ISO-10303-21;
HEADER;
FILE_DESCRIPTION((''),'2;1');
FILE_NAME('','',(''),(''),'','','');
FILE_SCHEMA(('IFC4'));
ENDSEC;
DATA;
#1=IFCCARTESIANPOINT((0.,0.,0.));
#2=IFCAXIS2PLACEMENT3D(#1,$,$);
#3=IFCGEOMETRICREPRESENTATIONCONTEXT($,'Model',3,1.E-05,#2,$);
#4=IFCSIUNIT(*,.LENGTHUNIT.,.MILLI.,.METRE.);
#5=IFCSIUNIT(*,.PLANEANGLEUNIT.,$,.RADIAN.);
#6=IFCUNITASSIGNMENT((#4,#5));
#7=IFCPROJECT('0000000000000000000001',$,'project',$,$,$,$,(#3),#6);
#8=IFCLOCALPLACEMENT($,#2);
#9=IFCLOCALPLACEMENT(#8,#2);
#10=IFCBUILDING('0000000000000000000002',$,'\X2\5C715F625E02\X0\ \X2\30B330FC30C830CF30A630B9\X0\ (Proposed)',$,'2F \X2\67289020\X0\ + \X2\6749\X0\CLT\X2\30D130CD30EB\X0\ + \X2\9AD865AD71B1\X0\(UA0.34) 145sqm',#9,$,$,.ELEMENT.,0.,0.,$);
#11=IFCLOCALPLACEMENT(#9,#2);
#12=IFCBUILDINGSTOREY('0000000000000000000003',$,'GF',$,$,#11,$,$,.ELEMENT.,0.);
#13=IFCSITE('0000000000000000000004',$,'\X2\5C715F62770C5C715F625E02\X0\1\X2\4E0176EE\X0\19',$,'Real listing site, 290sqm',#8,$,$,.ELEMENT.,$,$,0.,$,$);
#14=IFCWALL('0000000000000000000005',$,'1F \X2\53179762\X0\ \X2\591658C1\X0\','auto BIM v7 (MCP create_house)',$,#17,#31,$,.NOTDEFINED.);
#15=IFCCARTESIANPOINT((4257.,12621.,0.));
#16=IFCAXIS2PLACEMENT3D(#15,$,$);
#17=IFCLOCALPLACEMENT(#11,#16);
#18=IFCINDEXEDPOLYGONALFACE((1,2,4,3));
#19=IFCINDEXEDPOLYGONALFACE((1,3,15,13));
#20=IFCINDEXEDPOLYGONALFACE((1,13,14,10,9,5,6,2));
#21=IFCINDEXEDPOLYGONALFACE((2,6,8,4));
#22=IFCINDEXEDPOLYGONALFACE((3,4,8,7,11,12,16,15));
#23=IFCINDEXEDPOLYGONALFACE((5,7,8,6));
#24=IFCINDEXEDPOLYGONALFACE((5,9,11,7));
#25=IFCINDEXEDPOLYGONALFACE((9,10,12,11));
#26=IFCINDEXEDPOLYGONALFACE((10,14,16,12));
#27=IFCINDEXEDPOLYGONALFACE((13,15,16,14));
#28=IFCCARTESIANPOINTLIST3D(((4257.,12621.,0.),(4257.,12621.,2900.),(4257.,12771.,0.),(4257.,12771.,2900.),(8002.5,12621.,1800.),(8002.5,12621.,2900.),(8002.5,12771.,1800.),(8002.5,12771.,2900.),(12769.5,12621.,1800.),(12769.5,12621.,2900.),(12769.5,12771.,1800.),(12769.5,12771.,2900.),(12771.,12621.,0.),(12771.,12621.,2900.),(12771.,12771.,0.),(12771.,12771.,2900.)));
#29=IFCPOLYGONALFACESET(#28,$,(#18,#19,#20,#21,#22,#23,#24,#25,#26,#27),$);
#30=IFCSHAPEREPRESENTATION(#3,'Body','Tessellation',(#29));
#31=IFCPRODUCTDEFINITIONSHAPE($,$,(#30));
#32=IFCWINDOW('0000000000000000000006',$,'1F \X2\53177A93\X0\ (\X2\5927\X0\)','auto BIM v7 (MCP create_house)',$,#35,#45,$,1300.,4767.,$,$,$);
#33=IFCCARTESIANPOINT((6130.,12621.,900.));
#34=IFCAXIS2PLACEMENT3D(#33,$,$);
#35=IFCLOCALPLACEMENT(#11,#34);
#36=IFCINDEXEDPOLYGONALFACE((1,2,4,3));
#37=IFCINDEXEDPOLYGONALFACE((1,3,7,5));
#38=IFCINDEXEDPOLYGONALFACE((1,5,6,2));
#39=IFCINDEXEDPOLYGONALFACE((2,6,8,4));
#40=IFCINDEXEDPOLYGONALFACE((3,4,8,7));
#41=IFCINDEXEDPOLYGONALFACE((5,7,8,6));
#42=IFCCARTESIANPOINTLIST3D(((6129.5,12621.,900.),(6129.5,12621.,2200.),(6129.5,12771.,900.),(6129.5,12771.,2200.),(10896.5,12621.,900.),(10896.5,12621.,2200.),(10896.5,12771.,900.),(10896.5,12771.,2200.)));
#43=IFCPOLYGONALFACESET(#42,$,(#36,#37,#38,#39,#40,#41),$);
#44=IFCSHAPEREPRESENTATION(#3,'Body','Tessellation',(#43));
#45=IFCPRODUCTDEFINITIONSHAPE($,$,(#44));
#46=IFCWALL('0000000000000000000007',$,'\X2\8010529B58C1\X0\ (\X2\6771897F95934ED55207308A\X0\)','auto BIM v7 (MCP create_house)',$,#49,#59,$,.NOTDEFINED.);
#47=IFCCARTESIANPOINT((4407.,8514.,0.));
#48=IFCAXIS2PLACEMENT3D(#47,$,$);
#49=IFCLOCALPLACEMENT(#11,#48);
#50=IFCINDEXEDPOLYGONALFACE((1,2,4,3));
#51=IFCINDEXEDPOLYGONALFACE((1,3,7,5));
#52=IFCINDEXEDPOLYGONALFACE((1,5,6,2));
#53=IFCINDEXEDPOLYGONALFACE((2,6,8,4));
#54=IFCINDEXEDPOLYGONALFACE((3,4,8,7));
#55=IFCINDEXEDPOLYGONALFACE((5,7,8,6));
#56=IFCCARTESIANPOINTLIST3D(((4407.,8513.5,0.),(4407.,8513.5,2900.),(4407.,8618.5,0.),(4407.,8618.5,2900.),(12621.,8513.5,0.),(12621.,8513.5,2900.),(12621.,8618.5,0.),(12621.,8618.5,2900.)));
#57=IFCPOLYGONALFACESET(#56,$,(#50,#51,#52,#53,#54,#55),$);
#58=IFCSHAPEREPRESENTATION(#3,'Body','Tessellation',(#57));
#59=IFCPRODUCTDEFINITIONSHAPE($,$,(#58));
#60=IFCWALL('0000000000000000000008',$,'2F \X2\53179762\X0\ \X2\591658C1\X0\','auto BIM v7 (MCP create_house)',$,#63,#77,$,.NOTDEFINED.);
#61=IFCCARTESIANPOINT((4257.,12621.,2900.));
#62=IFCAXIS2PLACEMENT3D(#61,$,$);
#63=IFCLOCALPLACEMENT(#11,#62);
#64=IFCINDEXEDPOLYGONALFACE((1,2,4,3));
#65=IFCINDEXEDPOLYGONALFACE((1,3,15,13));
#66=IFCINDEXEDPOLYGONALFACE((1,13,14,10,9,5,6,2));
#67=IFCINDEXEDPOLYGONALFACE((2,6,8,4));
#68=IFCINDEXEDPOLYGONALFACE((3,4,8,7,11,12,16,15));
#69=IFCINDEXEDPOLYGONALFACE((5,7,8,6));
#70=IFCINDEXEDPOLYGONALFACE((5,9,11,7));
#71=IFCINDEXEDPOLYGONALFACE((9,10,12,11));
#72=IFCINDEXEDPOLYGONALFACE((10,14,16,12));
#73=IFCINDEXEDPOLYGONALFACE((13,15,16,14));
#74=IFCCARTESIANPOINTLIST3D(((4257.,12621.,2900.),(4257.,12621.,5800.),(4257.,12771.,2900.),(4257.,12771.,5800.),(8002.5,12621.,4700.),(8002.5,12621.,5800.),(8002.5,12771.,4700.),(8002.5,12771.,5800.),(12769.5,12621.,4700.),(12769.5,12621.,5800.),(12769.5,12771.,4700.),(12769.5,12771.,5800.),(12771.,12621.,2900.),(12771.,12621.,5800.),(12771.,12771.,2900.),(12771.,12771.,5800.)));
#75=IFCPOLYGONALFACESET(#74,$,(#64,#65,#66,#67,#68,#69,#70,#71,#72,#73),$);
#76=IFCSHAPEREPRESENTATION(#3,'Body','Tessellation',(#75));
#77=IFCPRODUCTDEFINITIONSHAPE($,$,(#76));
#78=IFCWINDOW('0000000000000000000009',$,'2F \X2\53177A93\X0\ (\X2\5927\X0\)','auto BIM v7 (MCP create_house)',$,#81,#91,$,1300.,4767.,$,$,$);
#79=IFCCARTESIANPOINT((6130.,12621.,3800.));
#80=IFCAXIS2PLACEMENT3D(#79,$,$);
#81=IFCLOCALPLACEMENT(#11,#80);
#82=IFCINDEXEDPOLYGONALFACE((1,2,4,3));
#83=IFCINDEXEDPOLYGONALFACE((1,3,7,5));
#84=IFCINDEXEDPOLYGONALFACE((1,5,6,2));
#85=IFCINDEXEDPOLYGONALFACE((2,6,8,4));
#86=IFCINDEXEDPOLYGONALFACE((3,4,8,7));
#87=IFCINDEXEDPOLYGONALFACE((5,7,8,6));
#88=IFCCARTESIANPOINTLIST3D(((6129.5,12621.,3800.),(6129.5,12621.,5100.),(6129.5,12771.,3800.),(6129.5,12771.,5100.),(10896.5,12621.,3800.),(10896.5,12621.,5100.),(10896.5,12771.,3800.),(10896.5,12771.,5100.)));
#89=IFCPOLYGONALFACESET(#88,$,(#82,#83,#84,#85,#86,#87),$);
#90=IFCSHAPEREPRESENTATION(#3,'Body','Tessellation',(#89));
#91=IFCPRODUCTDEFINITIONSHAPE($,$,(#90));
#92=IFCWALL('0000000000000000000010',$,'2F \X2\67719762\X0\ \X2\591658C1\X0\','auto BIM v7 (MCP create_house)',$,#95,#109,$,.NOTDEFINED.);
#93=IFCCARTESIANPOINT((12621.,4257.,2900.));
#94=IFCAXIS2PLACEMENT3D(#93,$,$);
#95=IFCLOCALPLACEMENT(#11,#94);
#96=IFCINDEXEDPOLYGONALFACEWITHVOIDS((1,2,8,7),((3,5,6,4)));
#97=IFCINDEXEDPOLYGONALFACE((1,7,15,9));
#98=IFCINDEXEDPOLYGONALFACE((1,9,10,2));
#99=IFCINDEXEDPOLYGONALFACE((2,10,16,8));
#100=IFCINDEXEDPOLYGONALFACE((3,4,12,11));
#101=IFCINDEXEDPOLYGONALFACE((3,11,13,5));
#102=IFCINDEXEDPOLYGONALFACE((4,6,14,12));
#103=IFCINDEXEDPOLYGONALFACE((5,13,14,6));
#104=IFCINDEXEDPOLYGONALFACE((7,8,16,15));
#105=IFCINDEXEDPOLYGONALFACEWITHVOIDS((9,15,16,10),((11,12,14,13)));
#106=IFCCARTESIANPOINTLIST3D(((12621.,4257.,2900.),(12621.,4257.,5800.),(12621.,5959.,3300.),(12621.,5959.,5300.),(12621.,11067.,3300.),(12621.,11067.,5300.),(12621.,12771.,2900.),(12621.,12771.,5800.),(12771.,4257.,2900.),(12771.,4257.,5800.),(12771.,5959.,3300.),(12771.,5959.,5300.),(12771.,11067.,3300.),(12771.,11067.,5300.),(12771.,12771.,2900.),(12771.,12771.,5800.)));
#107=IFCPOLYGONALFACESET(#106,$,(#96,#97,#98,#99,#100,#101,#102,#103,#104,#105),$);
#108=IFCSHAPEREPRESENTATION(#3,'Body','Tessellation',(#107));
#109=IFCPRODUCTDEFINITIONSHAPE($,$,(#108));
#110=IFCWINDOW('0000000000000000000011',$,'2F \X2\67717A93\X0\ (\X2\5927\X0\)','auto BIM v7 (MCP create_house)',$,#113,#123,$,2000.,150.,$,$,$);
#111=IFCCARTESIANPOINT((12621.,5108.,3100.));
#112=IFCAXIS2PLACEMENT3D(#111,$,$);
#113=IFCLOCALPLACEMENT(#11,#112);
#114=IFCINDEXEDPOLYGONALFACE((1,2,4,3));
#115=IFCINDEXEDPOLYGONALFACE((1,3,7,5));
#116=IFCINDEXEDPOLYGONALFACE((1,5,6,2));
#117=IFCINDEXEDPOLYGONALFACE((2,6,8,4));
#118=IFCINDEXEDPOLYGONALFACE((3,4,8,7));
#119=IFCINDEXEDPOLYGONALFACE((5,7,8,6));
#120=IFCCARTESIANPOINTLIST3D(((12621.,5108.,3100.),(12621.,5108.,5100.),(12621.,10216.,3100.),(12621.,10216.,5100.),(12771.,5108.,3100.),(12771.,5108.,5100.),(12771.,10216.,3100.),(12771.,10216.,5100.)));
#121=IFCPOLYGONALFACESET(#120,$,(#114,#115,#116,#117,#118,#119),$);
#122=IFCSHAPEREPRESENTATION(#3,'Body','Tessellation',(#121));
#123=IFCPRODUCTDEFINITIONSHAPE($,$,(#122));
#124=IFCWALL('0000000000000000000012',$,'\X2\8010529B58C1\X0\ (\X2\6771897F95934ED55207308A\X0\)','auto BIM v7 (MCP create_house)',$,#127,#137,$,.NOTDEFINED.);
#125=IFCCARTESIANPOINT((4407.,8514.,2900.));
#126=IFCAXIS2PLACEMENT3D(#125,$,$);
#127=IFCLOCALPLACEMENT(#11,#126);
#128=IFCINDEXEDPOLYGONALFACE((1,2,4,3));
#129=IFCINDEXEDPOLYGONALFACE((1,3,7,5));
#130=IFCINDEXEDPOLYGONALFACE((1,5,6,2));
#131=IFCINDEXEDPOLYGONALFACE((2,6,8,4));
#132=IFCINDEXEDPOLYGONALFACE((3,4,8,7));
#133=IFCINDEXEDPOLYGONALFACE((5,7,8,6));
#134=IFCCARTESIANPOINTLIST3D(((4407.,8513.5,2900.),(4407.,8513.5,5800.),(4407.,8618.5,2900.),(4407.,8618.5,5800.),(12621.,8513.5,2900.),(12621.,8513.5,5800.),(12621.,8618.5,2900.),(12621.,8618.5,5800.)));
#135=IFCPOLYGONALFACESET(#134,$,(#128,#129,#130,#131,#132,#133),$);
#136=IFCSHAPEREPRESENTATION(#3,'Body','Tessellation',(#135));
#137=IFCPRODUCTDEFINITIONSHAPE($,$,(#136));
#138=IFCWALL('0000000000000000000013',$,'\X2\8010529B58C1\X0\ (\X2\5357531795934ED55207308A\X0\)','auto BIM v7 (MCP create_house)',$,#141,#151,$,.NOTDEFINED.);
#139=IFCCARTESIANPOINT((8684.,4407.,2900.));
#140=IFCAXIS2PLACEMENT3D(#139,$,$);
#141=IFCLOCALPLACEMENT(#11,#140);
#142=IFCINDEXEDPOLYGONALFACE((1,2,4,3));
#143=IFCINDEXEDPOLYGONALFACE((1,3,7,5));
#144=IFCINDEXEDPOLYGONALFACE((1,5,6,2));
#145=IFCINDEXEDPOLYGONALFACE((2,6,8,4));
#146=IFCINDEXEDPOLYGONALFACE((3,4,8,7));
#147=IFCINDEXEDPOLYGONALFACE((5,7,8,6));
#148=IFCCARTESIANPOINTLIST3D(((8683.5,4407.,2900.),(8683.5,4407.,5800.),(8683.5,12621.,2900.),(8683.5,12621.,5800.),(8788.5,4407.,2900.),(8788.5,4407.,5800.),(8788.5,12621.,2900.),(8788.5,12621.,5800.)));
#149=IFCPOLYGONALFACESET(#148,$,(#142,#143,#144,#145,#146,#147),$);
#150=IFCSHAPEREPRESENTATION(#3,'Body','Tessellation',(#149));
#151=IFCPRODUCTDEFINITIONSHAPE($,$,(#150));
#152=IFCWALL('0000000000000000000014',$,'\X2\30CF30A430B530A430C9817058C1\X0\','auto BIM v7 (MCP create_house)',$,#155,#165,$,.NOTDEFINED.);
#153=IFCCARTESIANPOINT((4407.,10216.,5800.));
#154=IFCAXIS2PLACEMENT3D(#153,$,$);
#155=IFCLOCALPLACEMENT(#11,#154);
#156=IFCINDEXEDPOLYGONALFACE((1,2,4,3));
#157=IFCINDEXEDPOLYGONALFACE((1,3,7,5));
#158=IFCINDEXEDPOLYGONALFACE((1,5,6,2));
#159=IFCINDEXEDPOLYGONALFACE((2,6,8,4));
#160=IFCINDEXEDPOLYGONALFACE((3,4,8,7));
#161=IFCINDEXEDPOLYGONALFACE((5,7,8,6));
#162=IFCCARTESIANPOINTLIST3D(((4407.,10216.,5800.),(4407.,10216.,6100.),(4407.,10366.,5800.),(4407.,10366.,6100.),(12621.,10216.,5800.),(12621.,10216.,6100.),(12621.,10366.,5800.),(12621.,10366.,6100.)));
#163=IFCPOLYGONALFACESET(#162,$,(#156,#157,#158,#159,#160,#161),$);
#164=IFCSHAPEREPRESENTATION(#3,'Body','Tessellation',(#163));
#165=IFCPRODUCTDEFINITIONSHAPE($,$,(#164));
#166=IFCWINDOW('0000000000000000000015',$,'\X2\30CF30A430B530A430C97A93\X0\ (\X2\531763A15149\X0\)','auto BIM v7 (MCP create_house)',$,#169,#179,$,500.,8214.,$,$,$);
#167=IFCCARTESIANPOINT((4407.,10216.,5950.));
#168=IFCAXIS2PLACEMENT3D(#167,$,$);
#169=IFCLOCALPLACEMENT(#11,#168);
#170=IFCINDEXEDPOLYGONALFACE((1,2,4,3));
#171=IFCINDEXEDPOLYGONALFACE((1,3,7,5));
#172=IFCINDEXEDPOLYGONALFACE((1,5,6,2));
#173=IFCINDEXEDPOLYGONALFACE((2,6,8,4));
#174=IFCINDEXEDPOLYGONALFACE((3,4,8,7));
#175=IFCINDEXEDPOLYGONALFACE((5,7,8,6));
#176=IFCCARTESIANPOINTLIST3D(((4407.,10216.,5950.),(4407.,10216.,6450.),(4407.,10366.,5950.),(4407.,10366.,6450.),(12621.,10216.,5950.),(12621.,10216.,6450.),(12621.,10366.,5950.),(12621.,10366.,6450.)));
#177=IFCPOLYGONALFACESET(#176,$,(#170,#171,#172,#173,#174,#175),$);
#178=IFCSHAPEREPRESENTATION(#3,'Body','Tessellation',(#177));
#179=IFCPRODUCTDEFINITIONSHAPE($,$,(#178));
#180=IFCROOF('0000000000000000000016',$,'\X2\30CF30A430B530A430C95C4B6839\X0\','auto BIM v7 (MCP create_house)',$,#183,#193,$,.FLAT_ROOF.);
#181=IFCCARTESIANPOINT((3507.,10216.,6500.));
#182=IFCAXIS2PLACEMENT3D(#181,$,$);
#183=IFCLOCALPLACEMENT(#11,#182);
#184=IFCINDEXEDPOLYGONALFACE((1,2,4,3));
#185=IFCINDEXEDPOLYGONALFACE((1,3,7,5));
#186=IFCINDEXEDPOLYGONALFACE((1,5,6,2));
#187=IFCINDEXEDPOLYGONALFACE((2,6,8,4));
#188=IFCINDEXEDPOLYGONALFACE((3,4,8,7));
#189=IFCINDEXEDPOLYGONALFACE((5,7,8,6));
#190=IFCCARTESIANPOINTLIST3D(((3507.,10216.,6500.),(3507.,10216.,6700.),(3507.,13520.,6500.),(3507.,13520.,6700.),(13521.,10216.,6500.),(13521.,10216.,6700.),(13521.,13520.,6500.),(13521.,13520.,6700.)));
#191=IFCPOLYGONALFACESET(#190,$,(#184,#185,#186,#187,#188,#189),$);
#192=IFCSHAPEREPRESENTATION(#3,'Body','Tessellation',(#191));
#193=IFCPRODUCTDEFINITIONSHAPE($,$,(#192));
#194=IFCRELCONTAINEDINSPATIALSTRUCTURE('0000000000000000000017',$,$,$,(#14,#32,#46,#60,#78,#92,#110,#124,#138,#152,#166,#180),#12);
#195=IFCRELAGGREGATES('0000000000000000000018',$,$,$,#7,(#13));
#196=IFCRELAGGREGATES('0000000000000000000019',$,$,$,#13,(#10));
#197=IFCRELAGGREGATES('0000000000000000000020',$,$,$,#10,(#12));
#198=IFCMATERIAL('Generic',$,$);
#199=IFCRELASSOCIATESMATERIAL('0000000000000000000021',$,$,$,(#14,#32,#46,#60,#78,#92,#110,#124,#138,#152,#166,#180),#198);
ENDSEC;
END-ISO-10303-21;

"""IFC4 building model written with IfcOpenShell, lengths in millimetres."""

from ifc_helpers import new_model, si_unit, frame, frame_2d, origin, place, context, project, spatial, rectangle, extrude, material, element, fill, save


model = new_model("IFC4")

# Units and contexts
model_context = context("Model", 3, precision=1e-05, world=origin())
ifc_project = project(units=[si_unit("LENGTHUNIT", "METRE", prefix="MILLI"), si_unit("PLANEANGLEUNIT", "RADIAN")], contexts=[model_context])

# Site, building, storey
site_placement = place(None, origin())
site = spatial("IfcSite", under=ifc_project, at=site_placement, Name="山形県山形市1丁目19", ObjectType="Real listing site, 290sqm", CompositionType="ELEMENT", RefElevation=0.0)
building_placement = place(site_placement, origin())
building = spatial("IfcBuilding", under=site, at=building_placement, Name="山形市 コートハウス (Proposed)", ObjectType="2F 木造 + 杉CLTパネル + 高断熱(UA0.34) 145sqm", CompositionType="ELEMENT", ElevationOfRefHeight=0.0, ElevationOfTerrain=0.0)
storey_placement = place(building_placement, origin())
storey = spatial("IfcBuildingStorey", under=building, at=storey_placement, Name="GF", CompositionType="ELEMENT", Elevation=0.0)

# Wall, opening, window
ifc_material = material(Name="Generic")
wall_1_placement = place(storey_placement, frame((4257.0, 12621.0, 0.0)))
wall_1 = element("IfcWall", 1, at=wall_1_placement, inside=storey, material=ifc_material, Name="1F 北面 外壁", Description="auto BIM v7 (MCP create_house)", PredefinedType="NOTDEFINED", context=model_context, shape_type="SweptSolid", body=[
    extrude(rectangle(XDim=8514.0, YDim=150.0, at=frame_2d((4257.0, 75.0))), frame((4257.0, 12621.0, 0.0)), (0.0, 0.0, 1.0), 2900.0),
])
opening_1_placement = place(storey_placement, frame((6130.0, 12621.0, 900.0)))
opening_1 = element("IfcOpeningElement", 2, at=opening_1_placement, cuts=wall_1, PredefinedType="NOTDEFINED", context=model_context, shape_type="SweptSolid", body=[
    extrude(rectangle(XDim=4767.0, YDim=150.0, at=frame_2d((2383.0, 75.0))), frame((6130.0, 12621.0, 900.0)), (0.0, 0.0, 1.0), 1300.0),
])
window_1_placement = place(storey_placement, frame((6130.0, 12621.0, 900.0)))
window_1 = element("IfcWindow", 3, at=window_1_placement, inside=storey, material=ifc_material, Name="1F 北窓 (大)", Description="auto BIM v7 (MCP create_house)", OverallHeight=1300.0, OverallWidth=4767.0, context=model_context, shape_type="SweptSolid", body=[
    extrude(rectangle(XDim=4767.0, YDim=150.0, at=frame_2d((2383.0, 75.0))), frame((6130.0, 12621.0, 900.0)), (0.0, 0.0, 1.0), 1300.0),
])
fill(opening_1, window_1)

# Wall
wall_2_placement = place(storey_placement, frame((4407.0, 8514.0, 0.0)))
element("IfcWall", 4, at=wall_2_placement, inside=storey, material=ifc_material, Name="耐力壁 (東西間仕切り)", Description="auto BIM v7 (MCP create_house)", PredefinedType="NOTDEFINED", context=model_context, shape_type="SweptSolid", body=[
    extrude(rectangle(XDim=8214.0, YDim=105.0, at=frame_2d((4107.0, 52.0))), frame((4407.0, 8514.0, 0.0)), (0.0, 0.0, 1.0), 2900.0),
])

# Walls, openings, windows
wall_3_placement = place(storey_placement, frame((4257.0, 12621.0, 2900.0)))
wall_3 = element("IfcWall", 5, at=wall_3_placement, inside=storey, material=ifc_material, Name="2F 北面 外壁", Description="auto BIM v7 (MCP create_house)", PredefinedType="NOTDEFINED", context=model_context, shape_type="SweptSolid", body=[
    extrude(rectangle(XDim=8514.0, YDim=150.0, at=frame_2d((4257.0, 75.0))), frame((4257.0, 12621.0, 2900.0)), (0.0, 0.0, 1.0), 2900.0),
])
opening_2_placement = place(storey_placement, frame((6130.0, 12621.0, 3800.0)))
opening_2 = element("IfcOpeningElement", 6, at=opening_2_placement, cuts=wall_3, PredefinedType="NOTDEFINED", context=model_context, shape_type="SweptSolid", body=[
    extrude(rectangle(XDim=4767.0, YDim=150.0, at=frame_2d((2383.0, 75.0))), frame((6130.0, 12621.0, 3800.0)), (0.0, 0.0, 1.0), 1300.0),
])
window_2_placement = place(storey_placement, frame((6130.0, 12621.0, 3800.0)))
window_2 = element("IfcWindow", 7, at=window_2_placement, inside=storey, material=ifc_material, Name="2F 北窓 (大)", Description="auto BIM v7 (MCP create_house)", OverallHeight=1300.0, OverallWidth=4767.0, context=model_context, shape_type="SweptSolid", body=[
    extrude(rectangle(XDim=4767.0, YDim=150.0, at=frame_2d((2383.0, 75.0))), frame((6130.0, 12621.0, 3800.0)), (0.0, 0.0, 1.0), 1300.0),
])
fill(opening_2, window_2)
wall_4_placement = place(storey_placement, frame((12621.0, 4257.0, 2900.0)))
wall_4 = element("IfcWall", 8, at=wall_4_placement, inside=storey, material=ifc_material, Name="2F 東面 外壁", Description="auto BIM v7 (MCP create_house)", PredefinedType="NOTDEFINED", context=model_context, shape_type="SweptSolid", body=[
    extrude(rectangle(XDim=150.0, YDim=8514.0, at=frame_2d((75.0, 4257.0))), frame((12621.0, 4257.0, 2900.0)), (0.0, 0.0, 1.0), 2900.0),
])
opening_3_placement = place(storey_placement, frame((12621.0, 5108.0, 3100.0)))
opening_3 = element("IfcOpeningElement", 9, at=opening_3_placement, cuts=wall_4, PredefinedType="NOTDEFINED", context=model_context, shape_type="SweptSolid", body=[
    extrude(rectangle(XDim=150.0, YDim=5108.0, at=frame_2d((75.0, 2554.0))), frame((12621.0, 5108.0, 3100.0)), (0.0, 0.0, 1.0), 2000.0),
])
window_3_placement = place(storey_placement, frame((12621.0, 5108.0, 3100.0)))
window_3 = element("IfcWindow", 10, at=window_3_placement, inside=storey, material=ifc_material, Name="2F 東窓 (大)", Description="auto BIM v7 (MCP create_house)", OverallHeight=2000.0, OverallWidth=150.0, context=model_context, shape_type="SweptSolid", body=[
    extrude(rectangle(XDim=150.0, YDim=5108.0, at=frame_2d((75.0, 2554.0))), frame((12621.0, 5108.0, 3100.0)), (0.0, 0.0, 1.0), 2000.0),
])
fill(opening_3, window_3)

# Walls
wall_5_placement = place(storey_placement, frame((4407.0, 8514.0, 2900.0)))
element("IfcWall", 11, at=wall_5_placement, inside=storey, material=ifc_material, Name="耐力壁 (東西間仕切り)", Description="auto BIM v7 (MCP create_house)", PredefinedType="NOTDEFINED", context=model_context, shape_type="SweptSolid", body=[
    extrude(rectangle(XDim=8214.0, YDim=105.0, at=frame_2d((4107.0, 52.0))), frame((4407.0, 8514.0, 2900.0)), (0.0, 0.0, 1.0), 2900.0),
])
wall_6_placement = place(storey_placement, frame((8684.0, 4407.0, 2900.0)))
element("IfcWall", 12, at=wall_6_placement, inside=storey, material=ifc_material, Name="耐力壁 (南北間仕切り)", Description="auto BIM v7 (MCP create_house)", PredefinedType="NOTDEFINED", context=model_context, shape_type="SweptSolid", body=[
    extrude(rectangle(XDim=105.0, YDim=8214.0, at=frame_2d((52.0, 4107.0))), frame((8684.0, 4407.0, 2900.0)), (0.0, 0.0, 1.0), 2900.0),
])

# Wall, opening, window
wall_7_placement = place(storey_placement, frame((4407.0, 10216.0, 5800.0)))
wall_7 = element("IfcWall", 13, at=wall_7_placement, inside=storey, material=ifc_material, Name="ハイサイド腰壁", Description="auto BIM v7 (MCP create_house)", PredefinedType="NOTDEFINED", context=model_context, shape_type="SweptSolid", body=[
    extrude(rectangle(XDim=8214.0, YDim=150.0, at=frame_2d((4107.0, 75.0))), frame((4407.0, 10216.0, 5800.0)), (0.0, 0.0, 1.0), 700.0),
])
opening_4_placement = place(storey_placement, frame((4407.0, 10216.0, 5950.0)))
opening_4 = element("IfcOpeningElement", 14, at=opening_4_placement, cuts=wall_7, PredefinedType="NOTDEFINED", context=model_context, shape_type="SweptSolid", body=[
    extrude(rectangle(XDim=8214.0, YDim=150.0, at=frame_2d((4107.0, 75.0))), frame((4407.0, 10216.0, 5950.0)), (0.0, 0.0, 1.0), 500.0),
])
window_4_placement = place(storey_placement, frame((4407.0, 10216.0, 5950.0)))
window_4 = element("IfcWindow", 15, at=window_4_placement, inside=storey, material=ifc_material, Name="ハイサイド窓 (北採光)", Description="auto BIM v7 (MCP create_house)", OverallHeight=500.0, OverallWidth=8214.0, context=model_context, shape_type="SweptSolid", body=[
    extrude(rectangle(XDim=8214.0, YDim=150.0, at=frame_2d((4107.0, 75.0))), frame((4407.0, 10216.0, 5950.0)), (0.0, 0.0, 1.0), 500.0),
])
fill(opening_4, window_4)

# Roof
roof_placement = place(storey_placement, frame((3507.0, 10216.0, 6500.0)))
element("IfcRoof", 16, at=roof_placement, inside=storey, material=ifc_material, Name="ハイサイド屋根", Description="auto BIM v7 (MCP create_house)", PredefinedType="FLAT_ROOF", context=model_context, shape_type="SweptSolid", body=[
    extrude(rectangle(XDim=10014.0, YDim=3304.0, at=frame_2d((5007.0, 1652.0))), frame((3507.0, 10216.0, 6500.0)), (0.0, 0.0, 1.0), 200.0),
])

save(model, "model.ifc")
